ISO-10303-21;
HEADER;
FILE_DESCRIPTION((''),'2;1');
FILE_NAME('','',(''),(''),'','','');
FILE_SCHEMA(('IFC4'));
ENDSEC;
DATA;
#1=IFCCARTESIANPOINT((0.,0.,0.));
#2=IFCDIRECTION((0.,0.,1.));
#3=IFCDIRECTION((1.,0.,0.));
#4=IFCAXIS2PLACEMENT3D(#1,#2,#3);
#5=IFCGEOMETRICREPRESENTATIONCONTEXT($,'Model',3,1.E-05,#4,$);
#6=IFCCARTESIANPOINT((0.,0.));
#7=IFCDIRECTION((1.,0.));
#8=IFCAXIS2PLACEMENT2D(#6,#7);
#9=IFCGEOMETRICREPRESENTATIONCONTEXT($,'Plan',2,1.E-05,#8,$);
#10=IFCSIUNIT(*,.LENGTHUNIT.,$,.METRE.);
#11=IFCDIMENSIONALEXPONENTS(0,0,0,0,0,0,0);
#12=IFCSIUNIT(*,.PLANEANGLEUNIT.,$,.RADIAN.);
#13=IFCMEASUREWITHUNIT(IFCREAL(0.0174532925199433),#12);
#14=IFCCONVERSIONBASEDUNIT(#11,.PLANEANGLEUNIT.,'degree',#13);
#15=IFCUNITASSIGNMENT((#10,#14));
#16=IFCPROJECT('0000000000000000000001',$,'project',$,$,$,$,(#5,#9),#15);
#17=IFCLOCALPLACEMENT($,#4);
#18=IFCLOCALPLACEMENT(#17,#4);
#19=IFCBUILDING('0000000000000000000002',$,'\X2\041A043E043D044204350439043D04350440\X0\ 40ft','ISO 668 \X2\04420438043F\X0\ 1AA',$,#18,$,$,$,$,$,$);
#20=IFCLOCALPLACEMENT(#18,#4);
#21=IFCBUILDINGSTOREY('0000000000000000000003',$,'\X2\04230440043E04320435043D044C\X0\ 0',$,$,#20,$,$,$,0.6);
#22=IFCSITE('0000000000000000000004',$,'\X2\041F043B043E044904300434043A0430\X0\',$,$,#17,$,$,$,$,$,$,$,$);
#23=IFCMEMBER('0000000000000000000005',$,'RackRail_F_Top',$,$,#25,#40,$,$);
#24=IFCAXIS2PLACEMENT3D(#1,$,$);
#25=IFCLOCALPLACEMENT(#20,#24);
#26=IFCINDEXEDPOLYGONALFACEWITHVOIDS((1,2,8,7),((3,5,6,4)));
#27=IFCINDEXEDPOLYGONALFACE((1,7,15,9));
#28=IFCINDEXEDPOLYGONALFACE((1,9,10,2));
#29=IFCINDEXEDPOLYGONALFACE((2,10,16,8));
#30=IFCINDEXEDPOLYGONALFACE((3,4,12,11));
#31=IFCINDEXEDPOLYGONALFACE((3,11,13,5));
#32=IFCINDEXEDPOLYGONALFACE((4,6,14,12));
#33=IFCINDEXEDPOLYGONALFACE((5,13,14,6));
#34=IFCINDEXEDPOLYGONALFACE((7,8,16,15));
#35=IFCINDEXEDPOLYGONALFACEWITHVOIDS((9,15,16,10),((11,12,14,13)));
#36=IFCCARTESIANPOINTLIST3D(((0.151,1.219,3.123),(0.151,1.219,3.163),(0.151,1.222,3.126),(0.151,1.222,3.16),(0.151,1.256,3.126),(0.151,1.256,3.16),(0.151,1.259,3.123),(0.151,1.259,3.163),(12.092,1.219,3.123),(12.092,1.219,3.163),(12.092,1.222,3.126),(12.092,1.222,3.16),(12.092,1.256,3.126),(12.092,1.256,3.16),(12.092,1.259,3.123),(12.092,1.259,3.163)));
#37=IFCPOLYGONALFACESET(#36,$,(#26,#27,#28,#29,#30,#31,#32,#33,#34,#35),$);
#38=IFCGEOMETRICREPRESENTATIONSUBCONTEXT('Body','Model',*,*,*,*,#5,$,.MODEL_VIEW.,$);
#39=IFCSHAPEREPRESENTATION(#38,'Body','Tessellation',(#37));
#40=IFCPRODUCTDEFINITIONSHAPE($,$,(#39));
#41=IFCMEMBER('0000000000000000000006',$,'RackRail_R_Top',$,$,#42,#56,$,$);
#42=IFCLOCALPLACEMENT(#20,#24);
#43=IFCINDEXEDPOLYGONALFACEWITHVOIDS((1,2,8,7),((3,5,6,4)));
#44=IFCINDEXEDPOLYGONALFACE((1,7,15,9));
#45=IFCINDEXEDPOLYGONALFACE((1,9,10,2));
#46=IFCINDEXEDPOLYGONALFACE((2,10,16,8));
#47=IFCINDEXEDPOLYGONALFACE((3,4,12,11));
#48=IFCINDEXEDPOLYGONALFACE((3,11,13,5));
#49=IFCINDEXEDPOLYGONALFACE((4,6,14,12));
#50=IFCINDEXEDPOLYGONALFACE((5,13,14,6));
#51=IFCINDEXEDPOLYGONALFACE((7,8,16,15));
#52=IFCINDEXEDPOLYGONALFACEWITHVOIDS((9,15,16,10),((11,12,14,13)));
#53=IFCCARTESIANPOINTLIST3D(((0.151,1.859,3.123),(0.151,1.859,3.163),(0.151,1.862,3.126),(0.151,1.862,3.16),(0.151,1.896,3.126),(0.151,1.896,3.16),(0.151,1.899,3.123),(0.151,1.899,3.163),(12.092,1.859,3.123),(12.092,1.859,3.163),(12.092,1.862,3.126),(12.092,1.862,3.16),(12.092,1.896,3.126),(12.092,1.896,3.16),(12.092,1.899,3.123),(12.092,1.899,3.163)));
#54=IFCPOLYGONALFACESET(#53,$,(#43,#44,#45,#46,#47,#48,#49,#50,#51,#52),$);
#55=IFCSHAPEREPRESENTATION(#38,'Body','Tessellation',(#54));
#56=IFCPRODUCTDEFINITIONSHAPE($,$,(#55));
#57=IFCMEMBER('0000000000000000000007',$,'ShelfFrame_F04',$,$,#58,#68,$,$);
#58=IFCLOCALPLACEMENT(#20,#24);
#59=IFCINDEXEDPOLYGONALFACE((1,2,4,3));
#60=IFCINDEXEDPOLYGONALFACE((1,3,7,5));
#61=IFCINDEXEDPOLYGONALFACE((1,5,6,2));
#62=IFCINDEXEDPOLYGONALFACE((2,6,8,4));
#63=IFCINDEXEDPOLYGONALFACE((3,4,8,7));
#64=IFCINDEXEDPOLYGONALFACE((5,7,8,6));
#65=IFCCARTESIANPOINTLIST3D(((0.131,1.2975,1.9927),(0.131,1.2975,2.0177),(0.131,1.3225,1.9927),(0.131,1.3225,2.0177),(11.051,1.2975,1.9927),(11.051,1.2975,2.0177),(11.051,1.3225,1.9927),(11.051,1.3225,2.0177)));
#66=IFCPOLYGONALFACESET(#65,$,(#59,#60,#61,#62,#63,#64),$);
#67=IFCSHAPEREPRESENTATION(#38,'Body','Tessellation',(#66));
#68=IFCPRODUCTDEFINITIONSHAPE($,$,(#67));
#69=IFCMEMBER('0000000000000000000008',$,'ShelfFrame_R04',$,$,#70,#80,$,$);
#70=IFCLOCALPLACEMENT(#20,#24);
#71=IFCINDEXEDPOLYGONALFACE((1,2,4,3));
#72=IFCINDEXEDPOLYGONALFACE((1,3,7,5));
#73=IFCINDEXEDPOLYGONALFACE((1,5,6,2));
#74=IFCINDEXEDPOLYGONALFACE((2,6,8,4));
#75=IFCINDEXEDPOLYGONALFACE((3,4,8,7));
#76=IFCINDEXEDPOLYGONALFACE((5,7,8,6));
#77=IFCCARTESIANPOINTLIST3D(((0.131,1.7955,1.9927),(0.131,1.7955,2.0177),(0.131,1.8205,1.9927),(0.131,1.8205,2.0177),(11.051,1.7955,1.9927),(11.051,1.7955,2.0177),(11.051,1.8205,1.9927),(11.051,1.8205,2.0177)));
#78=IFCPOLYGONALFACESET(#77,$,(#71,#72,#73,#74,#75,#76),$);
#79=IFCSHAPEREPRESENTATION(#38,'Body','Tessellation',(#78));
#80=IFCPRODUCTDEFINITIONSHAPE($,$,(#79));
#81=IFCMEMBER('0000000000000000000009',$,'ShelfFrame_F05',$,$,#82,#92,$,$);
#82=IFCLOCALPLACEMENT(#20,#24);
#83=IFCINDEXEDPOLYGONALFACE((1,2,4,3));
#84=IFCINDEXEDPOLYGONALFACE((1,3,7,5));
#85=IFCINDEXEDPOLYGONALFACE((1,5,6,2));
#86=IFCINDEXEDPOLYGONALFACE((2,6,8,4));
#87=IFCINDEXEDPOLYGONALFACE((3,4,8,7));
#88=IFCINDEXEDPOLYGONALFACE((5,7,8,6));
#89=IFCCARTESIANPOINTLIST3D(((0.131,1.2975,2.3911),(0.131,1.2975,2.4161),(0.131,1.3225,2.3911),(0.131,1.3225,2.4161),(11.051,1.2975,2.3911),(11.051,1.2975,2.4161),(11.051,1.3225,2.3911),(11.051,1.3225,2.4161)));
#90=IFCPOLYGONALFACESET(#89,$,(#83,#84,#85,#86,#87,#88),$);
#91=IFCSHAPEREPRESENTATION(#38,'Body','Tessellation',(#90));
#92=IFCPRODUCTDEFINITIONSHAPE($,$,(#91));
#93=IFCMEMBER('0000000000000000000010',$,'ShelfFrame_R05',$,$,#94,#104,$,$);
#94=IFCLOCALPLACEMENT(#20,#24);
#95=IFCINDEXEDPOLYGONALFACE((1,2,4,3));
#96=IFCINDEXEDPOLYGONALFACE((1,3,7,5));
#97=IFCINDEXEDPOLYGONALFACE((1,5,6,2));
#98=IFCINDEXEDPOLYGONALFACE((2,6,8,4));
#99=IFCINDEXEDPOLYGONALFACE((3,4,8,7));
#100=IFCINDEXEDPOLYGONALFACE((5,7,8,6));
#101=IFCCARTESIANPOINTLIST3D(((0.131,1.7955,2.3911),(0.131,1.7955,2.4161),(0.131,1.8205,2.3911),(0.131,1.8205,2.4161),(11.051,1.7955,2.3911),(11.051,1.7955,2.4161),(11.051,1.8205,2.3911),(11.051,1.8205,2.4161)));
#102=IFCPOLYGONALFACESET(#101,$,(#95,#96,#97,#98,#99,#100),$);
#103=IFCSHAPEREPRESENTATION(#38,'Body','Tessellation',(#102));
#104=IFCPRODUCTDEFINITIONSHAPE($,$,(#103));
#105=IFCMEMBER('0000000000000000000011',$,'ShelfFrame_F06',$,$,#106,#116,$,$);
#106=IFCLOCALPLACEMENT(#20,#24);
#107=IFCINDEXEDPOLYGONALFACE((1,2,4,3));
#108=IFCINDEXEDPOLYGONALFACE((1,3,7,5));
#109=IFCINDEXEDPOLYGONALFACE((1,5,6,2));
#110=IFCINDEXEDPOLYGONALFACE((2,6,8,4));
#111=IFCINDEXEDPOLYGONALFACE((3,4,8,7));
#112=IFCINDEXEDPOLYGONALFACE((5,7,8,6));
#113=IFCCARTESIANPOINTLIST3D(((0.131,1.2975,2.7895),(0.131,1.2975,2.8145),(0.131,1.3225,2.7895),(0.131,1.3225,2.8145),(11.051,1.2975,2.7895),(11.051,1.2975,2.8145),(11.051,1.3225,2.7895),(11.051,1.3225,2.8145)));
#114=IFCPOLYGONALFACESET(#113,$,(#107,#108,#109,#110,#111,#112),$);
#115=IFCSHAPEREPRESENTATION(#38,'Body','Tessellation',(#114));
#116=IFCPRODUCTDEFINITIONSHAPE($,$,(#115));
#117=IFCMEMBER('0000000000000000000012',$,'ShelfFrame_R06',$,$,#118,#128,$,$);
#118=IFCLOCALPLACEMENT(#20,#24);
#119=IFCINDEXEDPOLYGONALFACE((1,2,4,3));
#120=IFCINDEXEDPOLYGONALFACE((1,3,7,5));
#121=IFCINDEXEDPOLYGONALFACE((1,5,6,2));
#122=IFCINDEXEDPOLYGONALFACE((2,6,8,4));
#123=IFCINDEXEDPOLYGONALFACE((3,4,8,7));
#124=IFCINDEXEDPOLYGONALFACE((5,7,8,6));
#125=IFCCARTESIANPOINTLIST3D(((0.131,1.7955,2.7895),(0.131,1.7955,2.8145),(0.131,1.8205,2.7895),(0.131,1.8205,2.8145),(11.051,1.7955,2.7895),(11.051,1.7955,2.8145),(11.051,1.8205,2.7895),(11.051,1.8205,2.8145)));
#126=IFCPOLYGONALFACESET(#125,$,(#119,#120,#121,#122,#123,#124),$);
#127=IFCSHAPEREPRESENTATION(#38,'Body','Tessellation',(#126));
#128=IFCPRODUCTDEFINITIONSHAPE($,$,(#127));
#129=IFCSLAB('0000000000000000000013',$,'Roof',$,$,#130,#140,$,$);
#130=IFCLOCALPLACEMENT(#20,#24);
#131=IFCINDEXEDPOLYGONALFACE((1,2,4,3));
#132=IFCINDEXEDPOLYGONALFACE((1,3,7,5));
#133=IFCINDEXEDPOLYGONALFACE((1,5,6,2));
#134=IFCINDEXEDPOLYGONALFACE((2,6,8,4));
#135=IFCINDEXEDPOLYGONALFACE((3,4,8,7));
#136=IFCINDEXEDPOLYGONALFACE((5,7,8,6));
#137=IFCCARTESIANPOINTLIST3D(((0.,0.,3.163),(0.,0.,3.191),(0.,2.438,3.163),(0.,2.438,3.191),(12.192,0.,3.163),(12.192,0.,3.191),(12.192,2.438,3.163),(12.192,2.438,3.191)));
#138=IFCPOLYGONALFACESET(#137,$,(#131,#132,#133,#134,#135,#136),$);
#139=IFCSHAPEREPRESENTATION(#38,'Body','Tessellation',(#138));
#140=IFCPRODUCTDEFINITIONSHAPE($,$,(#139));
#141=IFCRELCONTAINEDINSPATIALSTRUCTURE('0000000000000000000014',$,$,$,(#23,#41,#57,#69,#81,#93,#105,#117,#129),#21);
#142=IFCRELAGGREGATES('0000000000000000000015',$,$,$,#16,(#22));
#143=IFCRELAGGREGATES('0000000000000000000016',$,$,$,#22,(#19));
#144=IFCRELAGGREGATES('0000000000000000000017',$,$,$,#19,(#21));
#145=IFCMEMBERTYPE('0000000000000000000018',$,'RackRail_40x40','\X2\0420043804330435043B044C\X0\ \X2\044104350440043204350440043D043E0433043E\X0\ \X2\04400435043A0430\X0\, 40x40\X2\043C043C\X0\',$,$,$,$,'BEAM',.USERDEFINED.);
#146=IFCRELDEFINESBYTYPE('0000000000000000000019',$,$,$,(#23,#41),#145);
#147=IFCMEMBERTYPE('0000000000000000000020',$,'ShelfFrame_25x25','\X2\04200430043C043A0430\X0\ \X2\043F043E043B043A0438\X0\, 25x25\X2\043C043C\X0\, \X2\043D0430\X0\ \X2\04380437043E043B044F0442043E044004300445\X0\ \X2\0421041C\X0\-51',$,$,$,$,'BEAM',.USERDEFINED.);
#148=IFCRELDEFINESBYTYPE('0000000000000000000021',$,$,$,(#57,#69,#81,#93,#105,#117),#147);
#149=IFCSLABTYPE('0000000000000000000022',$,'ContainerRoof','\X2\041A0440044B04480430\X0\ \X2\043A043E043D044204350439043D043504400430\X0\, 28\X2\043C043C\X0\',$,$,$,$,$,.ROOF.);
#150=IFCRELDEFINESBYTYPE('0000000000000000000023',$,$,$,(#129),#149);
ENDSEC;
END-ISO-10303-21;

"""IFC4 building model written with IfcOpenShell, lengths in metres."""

from ifc_helpers import new_model, entity, si_unit, converted_unit, frame, origin_with_axes, origin_2d_with_axis, place, context, subcontext, project, spatial, indexed_curve, rectangle, hollow_rectangle, outline, extrude, type_object, element, save


model = new_model("IFC4")

# Units and contexts
model_context = context("Model", 3, precision=1e-05, world=origin_with_axes())
plan_context = context("Plan", 2, precision=1e-05, world=origin_2d_with_axis())
body_context = subcontext(model_context, "Body", "Model", "MODEL_VIEW")
ifc_project = project(units=[si_unit("LENGTHUNIT", "METRE"), converted_unit("PLANEANGLEUNIT", "degree", entity("IfcReal", 0.0174532925199433), si_unit("PLANEANGLEUNIT", "RADIAN"), dimensions=[0, 0, 0, 0, 0, 0, 0])], contexts=[model_context, plan_context])

# Site, building, storey
site_placement = place(None, origin_with_axes())
site = spatial("IfcSite", under=ifc_project, at=site_placement, Name="Площадка")
building_placement = place(site_placement, origin_with_axes())
building = spatial("IfcBuilding", under=site, at=building_placement, Name="Контейнер 40ft", Description="ISO 668 тип 1AA")
storey_placement = place(building_placement, origin_with_axes())
storey = spatial("IfcBuildingStorey", under=building, at=storey_placement, Name="Уровень 0", Elevation=0.6)

# Members
member_type_1 = type_object("IfcMemberType", Name="RackRail_40x40", Description="Ригель серверного река, 40x40мм", ElementType="BEAM", PredefinedType="USERDEFINED")
for number, where, z_axis, x_axis, name in (
    (1, (0.151, 1.239, 3.143), (1.0, 0.0, 0.0), (0.0, 1.0, 0.0), "RackRail_F_Top"),
    (2, (0.151, 1.879, 3.143), (1.0, 0.0, 0.0), (0.0, 1.0, 0.0), "RackRail_R_Top"),
):
    element("IfcMember", number, at=place(storey_placement, frame(where, z_axis=z_axis, x_axis=x_axis)), inside=storey, type_object=member_type_1, Name=name, context=body_context, shape_type="SweptSolid", body=[
        extrude(hollow_rectangle(XDim=0.04, YDim=0.04, WallThickness=0.003), origin_with_axes(), (0.0, 0.0, 1.0), 11.941),
    ])
member_type_2 = type_object("IfcMemberType", Name="ShelfFrame_25x25", Description="Рамка полки, 25x25мм, на изоляторах СМ-51", ElementType="BEAM", PredefinedType="USERDEFINED")
for number, where, z_axis, x_axis, name in (
    (3, (0.131, 1.31, 2.0052), (1.0, 0.0, 0.0), (0.0, 1.0, 0.0), "ShelfFrame_F04"),
    (4, (0.131, 1.808, 2.0052), (1.0, 0.0, 0.0), (0.0, 1.0, 0.0), "ShelfFrame_R04"),
    (5, (0.131, 1.31, 2.4036), (1.0, 0.0, 0.0), (0.0, 1.0, 0.0), "ShelfFrame_F05"),
    (6, (0.131, 1.808, 2.4036), (1.0, 0.0, 0.0), (0.0, 1.0, 0.0), "ShelfFrame_R05"),
    (7, (0.131, 1.31, 2.802), (1.0, 0.0, 0.0), (0.0, 1.0, 0.0), "ShelfFrame_F06"),
    (8, (0.131, 1.808, 2.802), (1.0, 0.0, 0.0), (0.0, 1.0, 0.0), "ShelfFrame_R06"),
):
    element("IfcMember", number, at=place(storey_placement, frame(where, z_axis=z_axis, x_axis=x_axis)), inside=storey, type_object=member_type_2, Name=name, context=body_context, shape_type="SweptSolid", body=[
        extrude(rectangle(XDim=0.025, YDim=0.025), origin_with_axes(), (0.0, 0.0, 1.0), 10.92),
    ])

# Slab
slab_type = type_object("IfcSlabType", Name="ContainerRoof", Description="Крыша контейнера, 28мм", PredefinedType="ROOF")
slab_placement = place(storey_placement, frame((0.0, 0.0, 3.163), z_axis=(0.0, 0.0, 1.0), x_axis=(1.0, 0.0, 0.0)))
element("IfcSlab", 9, at=slab_placement, inside=storey, type_object=slab_type, Name="Roof", context=body_context, shape_type="SweptSolid", body=[
    extrude(outline(indexed_curve([(0.0, 0.0), (12.192, 0.0), (12.192, 2.438), (0.0, 2.438)])), None, (0.0, 0.0, 1.0), 0.028),
])

save(model, "model.ifc")
